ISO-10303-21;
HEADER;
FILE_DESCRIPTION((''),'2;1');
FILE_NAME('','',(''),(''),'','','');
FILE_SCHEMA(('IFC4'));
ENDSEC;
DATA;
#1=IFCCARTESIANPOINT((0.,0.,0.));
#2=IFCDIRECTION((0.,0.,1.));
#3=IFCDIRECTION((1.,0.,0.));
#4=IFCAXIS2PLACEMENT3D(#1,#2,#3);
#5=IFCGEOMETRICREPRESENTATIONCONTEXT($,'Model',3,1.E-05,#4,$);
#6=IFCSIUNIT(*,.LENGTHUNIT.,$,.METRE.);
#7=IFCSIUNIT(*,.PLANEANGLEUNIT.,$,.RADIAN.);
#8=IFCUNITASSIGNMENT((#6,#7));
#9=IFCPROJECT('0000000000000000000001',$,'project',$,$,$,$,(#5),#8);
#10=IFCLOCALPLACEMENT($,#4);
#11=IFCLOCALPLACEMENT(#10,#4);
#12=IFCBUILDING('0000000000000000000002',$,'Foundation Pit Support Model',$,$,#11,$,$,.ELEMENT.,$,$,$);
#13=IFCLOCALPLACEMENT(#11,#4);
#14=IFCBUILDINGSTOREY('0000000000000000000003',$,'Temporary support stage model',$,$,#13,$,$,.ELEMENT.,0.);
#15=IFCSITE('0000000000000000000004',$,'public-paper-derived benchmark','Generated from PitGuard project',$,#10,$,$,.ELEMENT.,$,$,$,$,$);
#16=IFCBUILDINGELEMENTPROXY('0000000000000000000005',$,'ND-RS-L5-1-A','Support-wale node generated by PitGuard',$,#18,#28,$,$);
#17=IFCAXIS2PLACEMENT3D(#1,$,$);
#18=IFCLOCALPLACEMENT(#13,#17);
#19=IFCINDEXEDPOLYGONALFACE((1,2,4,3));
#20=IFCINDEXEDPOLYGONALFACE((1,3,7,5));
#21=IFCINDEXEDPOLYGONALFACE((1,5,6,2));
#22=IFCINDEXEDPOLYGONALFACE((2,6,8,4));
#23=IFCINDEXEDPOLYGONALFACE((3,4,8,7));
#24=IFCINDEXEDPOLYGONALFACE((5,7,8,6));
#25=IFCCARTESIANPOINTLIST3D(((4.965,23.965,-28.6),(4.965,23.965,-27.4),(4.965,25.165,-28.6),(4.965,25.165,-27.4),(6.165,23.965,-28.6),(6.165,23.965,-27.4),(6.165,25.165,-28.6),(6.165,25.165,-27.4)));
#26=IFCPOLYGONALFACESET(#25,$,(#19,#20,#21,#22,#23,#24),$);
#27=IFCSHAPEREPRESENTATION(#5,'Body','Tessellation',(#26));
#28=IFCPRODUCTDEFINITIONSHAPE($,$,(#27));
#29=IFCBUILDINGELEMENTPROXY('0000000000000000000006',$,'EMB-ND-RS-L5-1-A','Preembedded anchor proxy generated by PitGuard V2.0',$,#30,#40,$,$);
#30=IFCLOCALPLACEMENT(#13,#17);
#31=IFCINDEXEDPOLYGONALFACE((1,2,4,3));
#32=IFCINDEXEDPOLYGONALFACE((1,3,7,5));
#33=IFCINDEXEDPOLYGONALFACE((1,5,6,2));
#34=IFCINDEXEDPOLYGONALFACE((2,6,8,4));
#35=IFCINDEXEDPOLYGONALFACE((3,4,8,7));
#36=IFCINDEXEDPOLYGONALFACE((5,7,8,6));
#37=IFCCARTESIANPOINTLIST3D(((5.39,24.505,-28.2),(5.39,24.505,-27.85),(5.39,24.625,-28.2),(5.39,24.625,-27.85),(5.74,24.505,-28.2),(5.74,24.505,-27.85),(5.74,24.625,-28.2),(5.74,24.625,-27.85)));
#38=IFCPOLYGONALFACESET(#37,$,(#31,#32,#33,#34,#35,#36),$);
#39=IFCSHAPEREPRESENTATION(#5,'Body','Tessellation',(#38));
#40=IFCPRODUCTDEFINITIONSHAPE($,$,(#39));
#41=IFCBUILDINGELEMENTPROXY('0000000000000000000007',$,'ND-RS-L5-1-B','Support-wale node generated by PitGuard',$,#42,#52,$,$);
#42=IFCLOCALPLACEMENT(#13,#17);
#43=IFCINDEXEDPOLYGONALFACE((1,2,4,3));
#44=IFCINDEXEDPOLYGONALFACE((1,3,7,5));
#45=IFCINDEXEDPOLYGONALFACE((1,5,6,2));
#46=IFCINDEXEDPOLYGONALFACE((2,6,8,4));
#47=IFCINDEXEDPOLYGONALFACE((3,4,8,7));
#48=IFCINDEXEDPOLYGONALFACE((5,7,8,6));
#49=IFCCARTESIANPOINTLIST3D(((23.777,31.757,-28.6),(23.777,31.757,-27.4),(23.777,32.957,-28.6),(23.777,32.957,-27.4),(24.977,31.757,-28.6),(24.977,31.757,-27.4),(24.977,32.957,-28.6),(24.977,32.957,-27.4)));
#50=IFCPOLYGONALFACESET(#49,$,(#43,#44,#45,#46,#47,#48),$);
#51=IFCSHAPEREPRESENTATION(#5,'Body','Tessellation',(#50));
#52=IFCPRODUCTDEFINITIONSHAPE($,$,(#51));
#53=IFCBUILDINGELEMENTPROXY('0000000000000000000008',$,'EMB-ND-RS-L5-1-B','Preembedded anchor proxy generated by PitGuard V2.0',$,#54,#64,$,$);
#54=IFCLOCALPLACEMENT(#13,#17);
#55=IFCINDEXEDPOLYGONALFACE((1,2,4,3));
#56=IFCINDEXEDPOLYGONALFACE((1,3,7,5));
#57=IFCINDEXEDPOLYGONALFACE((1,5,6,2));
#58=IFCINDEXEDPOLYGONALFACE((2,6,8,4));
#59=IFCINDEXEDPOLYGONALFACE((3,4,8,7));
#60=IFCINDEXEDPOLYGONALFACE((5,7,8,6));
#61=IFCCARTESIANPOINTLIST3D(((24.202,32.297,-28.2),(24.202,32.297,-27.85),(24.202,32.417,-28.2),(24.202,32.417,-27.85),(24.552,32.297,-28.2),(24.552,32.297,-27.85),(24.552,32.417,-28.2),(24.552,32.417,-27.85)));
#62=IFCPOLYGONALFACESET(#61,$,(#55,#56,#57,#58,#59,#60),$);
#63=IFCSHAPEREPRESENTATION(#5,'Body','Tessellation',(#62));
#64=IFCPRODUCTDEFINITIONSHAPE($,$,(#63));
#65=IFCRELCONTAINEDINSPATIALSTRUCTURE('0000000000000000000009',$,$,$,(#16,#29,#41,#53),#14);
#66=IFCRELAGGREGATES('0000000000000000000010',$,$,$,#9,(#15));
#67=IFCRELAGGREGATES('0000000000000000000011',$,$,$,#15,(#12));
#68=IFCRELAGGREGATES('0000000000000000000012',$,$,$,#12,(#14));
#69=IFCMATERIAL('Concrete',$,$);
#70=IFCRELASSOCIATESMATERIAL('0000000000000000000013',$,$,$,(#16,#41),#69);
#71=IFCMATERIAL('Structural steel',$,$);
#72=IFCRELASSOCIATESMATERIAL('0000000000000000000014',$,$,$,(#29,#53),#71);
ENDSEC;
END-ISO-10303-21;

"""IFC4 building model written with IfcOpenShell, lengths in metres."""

from ifc_helpers import new_model, si_unit, frame, origin_with_axes, origin_2d, place, context, project, spatial, rectangle, extrude, material, element, save


model = new_model("IFC4")

# Units and contexts
model_context = context("Model", 3, precision=1e-05, world=origin_with_axes())
ifc_project = project(units=[si_unit("LENGTHUNIT", "METRE"), si_unit("PLANEANGLEUNIT", "RADIAN")], contexts=[model_context])

# Site, building, storey
site_placement = place(None, origin_with_axes())
site = spatial("IfcSite", under=ifc_project, at=site_placement, Name="public-paper-derived benchmark", Description="Generated from PitGuard project", CompositionType="ELEMENT")
building_placement = place(site_placement, origin_with_axes())
building = spatial("IfcBuilding", under=site, at=building_placement, Name="Foundation Pit Support Model", CompositionType="ELEMENT")
storey_placement = place(building_placement, origin_with_axes())
storey = spatial("IfcBuildingStorey", under=building, at=storey_placement, Name="Temporary support stage model", CompositionType="ELEMENT", Elevation=0.0)

# Shared definitions
ifc_material_1 = material(Name="Structural steel")

# Shared definitions
ifc_material_2 = material(Name="Concrete")

# Building element proxies
proxy_1_placement = place(storey_placement, frame((5.565, 24.565, -28.6), z_axis=(0.0, 0.0, 1.0), x_axis=(1.0, 0.0, 0.0)))
element("IfcBuildingElementProxy", 1, at=proxy_1_placement, inside=storey, material=ifc_material_2, Name="ND-RS-L5-1-A", Description="Support-wale node generated by PitGuard", context=model_context, shape_type="SweptSolid", body=[
    extrude(rectangle(XDim=1.2, YDim=1.2, at=origin_2d()), origin_with_axes(), (0.0, 0.0, 1.0), 1.2),
])
proxy_2_placement = place(storey_placement, frame((5.565, 24.565, -28.2), z_axis=(0.0, 0.0, 1.0), x_axis=(1.0, 0.0, 0.0)))
element("IfcBuildingElementProxy", 2, at=proxy_2_placement, inside=storey, material=ifc_material_1, Name="EMB-ND-RS-L5-1-A", Description="Preembedded anchor proxy generated by PitGuard V2.0", context=model_context, shape_type="SweptSolid", body=[
    extrude(rectangle(XDim=0.35, YDim=0.12, at=origin_2d()), origin_with_axes(), (0.0, 0.0, 1.0), 0.35),
])
proxy_3_placement = place(storey_placement, frame((24.377, 32.357, -28.6), z_axis=(0.0, 0.0, 1.0), x_axis=(1.0, 0.0, 0.0)))
element("IfcBuildingElementProxy", 3, at=proxy_3_placement, inside=storey, material=ifc_material_2, Name="ND-RS-L5-1-B", Description="Support-wale node generated by PitGuard", context=model_context, shape_type="SweptSolid", body=[
    extrude(rectangle(XDim=1.2, YDim=1.2, at=origin_2d()), origin_with_axes(), (0.0, 0.0, 1.0), 1.2),
])
proxy_4_placement = place(storey_placement, frame((24.377, 32.357, -28.2), z_axis=(0.0, 0.0, 1.0), x_axis=(1.0, 0.0, 0.0)))
element("IfcBuildingElementProxy", 4, at=proxy_4_placement, inside=storey, material=ifc_material_1, Name="EMB-ND-RS-L5-1-B", Description="Preembedded anchor proxy generated by PitGuard V2.0", context=model_context, shape_type="SweptSolid", body=[
    extrude(rectangle(XDim=0.35, YDim=0.12, at=origin_2d()), origin_with_axes(), (0.0, 0.0, 1.0), 0.35),
])

save(model, "model.ifc")
